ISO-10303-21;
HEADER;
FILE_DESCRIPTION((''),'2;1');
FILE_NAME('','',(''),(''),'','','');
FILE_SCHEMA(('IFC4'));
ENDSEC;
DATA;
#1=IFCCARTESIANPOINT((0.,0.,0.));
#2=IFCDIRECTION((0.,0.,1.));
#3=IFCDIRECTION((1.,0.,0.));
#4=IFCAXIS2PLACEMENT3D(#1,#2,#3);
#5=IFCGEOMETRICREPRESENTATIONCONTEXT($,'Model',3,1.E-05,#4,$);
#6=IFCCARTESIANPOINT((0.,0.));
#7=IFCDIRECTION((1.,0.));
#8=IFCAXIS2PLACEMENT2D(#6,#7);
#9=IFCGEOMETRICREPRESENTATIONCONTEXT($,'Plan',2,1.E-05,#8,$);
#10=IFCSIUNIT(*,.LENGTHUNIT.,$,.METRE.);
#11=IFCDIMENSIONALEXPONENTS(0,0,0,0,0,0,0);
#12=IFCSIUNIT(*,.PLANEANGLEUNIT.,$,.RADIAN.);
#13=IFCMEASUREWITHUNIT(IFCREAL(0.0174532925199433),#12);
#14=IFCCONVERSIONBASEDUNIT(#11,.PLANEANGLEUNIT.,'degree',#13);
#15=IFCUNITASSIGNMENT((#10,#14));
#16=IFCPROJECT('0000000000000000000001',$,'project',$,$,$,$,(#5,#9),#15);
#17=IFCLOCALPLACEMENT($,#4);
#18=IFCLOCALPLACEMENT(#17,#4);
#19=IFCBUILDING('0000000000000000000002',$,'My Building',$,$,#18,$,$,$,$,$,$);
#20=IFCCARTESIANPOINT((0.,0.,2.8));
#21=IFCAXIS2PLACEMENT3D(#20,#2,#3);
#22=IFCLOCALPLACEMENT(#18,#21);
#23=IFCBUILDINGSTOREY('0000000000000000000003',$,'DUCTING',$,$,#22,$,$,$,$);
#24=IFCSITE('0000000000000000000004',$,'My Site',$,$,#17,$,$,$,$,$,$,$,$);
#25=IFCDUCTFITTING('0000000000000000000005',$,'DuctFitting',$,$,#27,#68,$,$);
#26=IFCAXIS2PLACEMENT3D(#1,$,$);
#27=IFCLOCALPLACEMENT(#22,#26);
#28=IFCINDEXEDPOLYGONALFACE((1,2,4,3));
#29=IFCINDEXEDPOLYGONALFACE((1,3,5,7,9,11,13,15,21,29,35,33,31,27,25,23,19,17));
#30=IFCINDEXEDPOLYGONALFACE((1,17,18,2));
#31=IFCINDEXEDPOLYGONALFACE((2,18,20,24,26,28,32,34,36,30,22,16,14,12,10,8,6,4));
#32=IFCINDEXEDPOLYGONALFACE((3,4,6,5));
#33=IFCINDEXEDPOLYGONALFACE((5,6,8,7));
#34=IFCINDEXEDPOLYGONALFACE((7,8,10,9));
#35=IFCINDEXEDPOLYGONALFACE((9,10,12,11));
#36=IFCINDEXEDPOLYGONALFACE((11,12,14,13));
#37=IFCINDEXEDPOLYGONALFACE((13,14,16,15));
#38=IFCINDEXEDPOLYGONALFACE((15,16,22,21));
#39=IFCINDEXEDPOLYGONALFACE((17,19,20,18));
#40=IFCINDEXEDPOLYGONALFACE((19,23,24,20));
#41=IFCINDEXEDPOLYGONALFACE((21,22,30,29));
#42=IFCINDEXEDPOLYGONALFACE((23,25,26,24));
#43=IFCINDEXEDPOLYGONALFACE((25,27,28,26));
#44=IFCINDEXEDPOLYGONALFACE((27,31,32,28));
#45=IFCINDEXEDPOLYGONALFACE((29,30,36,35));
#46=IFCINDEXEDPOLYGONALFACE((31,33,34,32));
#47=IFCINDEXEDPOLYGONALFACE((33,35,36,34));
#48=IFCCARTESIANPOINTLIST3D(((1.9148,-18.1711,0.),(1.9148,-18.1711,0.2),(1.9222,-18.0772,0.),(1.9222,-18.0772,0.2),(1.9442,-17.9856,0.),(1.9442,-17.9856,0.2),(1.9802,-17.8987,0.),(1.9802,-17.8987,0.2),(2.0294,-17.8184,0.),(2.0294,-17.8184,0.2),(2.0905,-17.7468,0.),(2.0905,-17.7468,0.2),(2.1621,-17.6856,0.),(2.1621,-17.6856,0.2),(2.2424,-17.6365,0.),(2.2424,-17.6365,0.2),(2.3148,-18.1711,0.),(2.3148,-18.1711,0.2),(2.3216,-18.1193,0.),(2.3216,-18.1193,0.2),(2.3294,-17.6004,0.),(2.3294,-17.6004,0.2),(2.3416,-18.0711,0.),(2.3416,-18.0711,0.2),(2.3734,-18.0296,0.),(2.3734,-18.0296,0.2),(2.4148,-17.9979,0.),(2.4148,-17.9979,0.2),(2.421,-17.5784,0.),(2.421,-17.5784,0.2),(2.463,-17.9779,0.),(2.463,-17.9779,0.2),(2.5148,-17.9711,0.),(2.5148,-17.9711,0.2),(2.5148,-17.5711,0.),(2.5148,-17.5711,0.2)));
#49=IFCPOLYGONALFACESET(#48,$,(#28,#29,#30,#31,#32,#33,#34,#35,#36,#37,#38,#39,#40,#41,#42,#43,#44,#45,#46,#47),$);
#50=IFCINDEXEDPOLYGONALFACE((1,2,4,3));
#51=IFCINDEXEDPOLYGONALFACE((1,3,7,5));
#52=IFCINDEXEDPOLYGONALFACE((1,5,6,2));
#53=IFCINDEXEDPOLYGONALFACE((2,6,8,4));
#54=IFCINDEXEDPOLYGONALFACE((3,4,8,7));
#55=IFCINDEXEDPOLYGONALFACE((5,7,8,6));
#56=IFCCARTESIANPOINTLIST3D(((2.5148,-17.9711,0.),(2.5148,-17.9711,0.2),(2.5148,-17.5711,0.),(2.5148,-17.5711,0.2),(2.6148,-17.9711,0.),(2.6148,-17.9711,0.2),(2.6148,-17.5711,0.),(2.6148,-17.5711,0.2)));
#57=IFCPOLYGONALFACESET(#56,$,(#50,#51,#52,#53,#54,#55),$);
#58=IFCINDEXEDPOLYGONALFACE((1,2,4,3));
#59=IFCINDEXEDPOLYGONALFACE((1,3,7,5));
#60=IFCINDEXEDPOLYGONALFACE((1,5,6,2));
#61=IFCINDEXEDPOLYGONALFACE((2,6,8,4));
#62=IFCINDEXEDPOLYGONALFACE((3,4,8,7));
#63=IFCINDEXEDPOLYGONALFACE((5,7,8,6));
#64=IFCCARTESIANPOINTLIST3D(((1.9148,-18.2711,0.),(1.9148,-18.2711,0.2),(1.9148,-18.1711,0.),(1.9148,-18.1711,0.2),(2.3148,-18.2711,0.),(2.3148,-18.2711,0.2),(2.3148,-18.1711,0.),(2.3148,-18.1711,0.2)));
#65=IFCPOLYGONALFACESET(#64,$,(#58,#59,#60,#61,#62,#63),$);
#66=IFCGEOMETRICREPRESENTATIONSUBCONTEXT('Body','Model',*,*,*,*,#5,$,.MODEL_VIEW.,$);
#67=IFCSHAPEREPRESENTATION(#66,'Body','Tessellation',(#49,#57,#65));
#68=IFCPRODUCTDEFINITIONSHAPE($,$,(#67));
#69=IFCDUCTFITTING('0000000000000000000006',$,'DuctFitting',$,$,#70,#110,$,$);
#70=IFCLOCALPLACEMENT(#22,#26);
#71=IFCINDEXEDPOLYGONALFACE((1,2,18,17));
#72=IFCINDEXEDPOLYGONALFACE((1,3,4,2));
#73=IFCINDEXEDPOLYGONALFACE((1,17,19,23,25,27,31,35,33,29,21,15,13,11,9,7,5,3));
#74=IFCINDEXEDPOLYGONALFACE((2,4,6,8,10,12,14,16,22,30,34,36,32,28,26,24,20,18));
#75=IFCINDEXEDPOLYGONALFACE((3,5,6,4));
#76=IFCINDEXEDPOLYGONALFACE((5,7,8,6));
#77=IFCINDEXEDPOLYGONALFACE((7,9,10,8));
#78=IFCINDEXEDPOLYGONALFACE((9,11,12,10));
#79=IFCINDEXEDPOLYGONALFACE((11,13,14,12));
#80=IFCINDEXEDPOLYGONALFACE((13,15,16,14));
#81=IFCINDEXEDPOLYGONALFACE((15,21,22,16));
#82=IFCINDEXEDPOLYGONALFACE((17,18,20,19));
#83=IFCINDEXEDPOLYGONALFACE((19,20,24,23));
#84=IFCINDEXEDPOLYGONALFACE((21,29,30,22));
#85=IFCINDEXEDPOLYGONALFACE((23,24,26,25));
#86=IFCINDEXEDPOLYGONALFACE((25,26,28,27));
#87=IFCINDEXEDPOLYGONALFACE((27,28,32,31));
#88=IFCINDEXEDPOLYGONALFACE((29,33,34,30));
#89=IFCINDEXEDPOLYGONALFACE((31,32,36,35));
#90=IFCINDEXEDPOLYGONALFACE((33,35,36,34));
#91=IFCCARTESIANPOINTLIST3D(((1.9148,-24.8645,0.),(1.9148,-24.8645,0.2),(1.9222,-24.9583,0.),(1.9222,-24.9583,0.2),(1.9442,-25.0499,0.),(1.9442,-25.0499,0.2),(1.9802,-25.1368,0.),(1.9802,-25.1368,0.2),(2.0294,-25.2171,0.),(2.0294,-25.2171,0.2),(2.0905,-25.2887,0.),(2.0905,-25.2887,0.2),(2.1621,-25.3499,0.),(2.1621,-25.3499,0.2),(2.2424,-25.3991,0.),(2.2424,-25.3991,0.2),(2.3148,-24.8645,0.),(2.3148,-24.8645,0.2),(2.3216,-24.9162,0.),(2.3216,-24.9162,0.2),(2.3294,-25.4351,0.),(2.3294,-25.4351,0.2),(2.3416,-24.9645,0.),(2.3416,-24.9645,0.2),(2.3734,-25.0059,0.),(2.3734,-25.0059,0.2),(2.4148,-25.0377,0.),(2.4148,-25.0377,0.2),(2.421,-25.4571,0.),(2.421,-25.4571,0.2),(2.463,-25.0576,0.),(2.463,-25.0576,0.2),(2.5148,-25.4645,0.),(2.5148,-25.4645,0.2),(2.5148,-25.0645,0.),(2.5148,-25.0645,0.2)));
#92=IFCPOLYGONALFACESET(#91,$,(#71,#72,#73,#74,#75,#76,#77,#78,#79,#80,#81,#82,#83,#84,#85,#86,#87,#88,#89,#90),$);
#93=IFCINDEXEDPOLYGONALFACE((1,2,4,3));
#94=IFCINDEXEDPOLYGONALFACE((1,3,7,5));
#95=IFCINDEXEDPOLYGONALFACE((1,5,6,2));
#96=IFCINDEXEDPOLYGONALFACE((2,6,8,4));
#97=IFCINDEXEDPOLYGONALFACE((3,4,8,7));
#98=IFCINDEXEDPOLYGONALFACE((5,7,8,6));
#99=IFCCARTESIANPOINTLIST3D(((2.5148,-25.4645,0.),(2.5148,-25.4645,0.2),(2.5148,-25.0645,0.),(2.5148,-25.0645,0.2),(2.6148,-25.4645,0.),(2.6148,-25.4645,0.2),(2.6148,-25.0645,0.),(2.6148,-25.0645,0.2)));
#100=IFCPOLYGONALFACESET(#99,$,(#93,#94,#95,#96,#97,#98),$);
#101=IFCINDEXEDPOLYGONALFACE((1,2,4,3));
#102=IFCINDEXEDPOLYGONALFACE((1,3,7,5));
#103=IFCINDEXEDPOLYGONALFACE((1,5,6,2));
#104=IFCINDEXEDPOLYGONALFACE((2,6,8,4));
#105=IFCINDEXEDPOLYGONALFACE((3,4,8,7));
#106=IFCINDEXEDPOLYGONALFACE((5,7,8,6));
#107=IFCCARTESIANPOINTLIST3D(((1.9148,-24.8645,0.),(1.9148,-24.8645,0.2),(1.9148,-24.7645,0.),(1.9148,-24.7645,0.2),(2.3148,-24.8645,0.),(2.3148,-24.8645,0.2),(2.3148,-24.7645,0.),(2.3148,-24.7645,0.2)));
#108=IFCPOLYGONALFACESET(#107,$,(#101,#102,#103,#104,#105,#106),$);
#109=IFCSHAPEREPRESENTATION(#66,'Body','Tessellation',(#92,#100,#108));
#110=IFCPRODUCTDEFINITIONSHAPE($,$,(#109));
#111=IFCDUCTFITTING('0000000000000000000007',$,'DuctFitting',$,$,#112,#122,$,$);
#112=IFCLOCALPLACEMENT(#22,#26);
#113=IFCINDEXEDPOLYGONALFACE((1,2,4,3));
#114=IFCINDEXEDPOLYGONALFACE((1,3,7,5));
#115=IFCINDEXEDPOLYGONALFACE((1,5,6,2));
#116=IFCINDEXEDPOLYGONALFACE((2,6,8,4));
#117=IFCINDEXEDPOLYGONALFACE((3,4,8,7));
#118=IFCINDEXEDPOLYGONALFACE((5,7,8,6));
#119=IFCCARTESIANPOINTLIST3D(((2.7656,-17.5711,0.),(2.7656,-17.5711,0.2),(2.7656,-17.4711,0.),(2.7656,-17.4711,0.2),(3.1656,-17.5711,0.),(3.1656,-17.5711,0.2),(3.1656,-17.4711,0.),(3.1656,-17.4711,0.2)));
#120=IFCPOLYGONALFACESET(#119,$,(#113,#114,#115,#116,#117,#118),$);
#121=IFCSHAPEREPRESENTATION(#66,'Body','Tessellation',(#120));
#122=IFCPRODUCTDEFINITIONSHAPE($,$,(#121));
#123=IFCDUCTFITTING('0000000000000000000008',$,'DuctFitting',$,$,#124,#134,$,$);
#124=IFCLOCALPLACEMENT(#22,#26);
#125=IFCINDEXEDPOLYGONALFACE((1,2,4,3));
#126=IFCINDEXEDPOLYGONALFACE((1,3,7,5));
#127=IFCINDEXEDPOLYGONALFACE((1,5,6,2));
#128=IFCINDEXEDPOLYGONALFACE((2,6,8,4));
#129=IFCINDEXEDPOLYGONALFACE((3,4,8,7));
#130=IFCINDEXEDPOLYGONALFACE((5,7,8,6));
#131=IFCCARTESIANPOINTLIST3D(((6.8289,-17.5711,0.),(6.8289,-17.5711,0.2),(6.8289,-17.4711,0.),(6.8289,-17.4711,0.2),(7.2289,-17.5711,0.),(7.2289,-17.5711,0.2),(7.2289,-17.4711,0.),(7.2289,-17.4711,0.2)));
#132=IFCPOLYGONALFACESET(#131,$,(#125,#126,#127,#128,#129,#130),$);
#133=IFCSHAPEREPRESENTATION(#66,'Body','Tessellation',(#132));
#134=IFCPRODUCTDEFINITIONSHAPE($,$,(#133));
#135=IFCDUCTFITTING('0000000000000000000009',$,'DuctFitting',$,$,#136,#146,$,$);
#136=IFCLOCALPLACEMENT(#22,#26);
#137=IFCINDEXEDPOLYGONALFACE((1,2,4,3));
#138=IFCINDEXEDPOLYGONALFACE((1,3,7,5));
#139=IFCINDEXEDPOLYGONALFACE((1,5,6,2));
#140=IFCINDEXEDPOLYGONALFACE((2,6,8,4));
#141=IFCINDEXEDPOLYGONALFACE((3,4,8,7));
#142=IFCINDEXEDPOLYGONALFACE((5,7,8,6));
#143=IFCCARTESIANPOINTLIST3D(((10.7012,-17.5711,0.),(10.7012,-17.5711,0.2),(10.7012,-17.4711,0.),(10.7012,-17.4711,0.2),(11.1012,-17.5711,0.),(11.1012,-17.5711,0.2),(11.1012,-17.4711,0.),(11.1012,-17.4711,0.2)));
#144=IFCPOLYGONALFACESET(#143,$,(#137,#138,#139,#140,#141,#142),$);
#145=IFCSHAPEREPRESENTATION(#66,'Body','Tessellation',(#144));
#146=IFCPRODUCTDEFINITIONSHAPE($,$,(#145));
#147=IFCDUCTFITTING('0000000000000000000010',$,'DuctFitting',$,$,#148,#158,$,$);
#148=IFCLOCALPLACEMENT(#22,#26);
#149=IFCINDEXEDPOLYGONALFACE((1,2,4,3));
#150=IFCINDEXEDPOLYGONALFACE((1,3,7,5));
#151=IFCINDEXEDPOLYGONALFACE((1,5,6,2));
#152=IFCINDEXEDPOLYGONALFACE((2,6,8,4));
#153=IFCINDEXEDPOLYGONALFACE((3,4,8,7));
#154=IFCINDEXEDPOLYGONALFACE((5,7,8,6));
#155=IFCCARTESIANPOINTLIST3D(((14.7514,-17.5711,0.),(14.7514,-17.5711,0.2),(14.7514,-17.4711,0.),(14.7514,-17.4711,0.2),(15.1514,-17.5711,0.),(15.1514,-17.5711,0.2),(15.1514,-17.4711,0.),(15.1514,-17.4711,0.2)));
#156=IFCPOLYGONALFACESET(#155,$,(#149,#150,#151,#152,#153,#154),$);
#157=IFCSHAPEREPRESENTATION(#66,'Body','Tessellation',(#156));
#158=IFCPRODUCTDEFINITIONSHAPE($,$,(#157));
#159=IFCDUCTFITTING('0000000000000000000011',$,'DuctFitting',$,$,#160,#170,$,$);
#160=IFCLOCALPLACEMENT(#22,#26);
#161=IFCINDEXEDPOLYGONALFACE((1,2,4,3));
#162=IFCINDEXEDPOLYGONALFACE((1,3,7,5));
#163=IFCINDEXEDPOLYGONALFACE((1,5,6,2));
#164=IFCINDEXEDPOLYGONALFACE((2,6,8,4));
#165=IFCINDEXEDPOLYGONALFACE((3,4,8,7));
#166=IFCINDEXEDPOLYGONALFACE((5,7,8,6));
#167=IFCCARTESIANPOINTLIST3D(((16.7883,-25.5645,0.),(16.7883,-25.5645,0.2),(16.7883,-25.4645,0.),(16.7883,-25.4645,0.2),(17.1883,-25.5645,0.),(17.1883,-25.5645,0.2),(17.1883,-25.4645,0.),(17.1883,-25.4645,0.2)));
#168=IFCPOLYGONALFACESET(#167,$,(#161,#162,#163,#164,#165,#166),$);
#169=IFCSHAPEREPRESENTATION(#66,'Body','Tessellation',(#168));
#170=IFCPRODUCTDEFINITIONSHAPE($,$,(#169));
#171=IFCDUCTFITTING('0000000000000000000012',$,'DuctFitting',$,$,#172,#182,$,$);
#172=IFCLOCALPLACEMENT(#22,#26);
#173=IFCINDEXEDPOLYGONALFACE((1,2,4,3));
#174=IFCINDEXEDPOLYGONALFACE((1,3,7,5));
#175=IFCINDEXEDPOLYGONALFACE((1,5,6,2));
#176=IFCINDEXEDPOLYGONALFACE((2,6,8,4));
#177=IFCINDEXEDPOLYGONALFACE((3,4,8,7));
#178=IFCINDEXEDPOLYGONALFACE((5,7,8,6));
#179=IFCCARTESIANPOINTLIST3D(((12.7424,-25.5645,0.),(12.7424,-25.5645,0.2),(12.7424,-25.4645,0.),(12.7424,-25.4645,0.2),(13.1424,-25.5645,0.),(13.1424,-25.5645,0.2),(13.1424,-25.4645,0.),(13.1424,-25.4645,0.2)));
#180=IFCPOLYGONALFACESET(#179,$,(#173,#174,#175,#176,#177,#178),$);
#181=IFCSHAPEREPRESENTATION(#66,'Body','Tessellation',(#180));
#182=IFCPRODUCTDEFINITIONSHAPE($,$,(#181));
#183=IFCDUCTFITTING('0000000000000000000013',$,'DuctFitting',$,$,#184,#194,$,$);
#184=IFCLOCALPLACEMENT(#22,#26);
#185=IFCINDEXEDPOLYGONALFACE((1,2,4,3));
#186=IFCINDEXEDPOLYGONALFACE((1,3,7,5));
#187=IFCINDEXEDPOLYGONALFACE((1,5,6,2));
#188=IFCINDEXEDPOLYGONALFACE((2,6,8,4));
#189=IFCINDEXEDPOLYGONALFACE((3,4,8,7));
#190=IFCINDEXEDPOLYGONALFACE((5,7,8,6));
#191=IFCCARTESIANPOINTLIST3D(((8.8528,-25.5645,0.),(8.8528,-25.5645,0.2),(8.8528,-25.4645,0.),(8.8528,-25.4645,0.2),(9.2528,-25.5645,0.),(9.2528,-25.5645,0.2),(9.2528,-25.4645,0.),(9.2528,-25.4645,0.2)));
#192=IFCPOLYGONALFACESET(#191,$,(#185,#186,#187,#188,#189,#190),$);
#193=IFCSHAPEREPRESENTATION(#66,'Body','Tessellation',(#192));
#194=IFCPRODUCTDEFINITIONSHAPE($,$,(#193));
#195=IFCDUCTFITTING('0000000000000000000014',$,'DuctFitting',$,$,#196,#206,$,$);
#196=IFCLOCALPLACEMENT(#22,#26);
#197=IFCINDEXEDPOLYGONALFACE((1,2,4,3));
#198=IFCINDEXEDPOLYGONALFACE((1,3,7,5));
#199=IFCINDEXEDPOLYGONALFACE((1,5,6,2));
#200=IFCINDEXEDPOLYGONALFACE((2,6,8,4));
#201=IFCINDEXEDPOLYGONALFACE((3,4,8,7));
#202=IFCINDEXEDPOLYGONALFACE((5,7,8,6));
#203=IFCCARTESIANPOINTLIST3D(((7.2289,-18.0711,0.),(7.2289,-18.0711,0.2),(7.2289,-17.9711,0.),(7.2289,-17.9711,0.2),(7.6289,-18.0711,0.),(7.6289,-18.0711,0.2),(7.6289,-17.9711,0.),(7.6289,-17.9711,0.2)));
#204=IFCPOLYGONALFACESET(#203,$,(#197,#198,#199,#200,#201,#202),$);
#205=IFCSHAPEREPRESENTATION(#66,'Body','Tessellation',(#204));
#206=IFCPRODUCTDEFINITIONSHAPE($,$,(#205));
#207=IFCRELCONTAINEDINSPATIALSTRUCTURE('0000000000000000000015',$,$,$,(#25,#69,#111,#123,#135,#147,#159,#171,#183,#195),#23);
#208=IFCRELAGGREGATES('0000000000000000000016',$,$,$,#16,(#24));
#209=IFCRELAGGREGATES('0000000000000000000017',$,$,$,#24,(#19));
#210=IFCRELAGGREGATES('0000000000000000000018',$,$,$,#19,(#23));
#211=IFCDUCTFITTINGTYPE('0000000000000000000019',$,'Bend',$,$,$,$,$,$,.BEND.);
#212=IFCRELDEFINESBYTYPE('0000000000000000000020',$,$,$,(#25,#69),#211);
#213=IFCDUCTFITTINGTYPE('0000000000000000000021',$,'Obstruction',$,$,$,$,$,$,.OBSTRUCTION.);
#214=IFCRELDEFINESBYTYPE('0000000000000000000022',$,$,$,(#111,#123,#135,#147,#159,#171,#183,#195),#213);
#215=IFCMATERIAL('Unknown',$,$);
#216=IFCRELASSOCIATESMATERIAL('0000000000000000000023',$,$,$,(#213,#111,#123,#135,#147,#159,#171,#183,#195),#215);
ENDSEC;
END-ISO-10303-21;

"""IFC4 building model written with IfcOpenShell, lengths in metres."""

from ifc_helpers import new_model, entity, si_unit, converted_unit, frame, origin_with_axes, origin_2d_with_axis, place, context, subcontext, project, spatial, line, arc, indexed_curve, rectangle, outline, extrude, source, transform, mapped, material, material_profile, profile_set, profile_usage, type_object, type_shapes, element, save


model = new_model("IFC4")

# Units and contexts
model_context = context("Model", 3, precision=1e-05, world=origin_with_axes())
plan_context = context("Plan", 2, precision=1e-05, world=origin_2d_with_axis())
body_context = subcontext(model_context, "Body", "Model", "MODEL_VIEW")
ifc_project = project(units=[si_unit("LENGTHUNIT", "METRE"), converted_unit("PLANEANGLEUNIT", "degree", entity("IfcReal", 0.0174532925199433), si_unit("PLANEANGLEUNIT", "RADIAN"), dimensions=[0, 0, 0, 0, 0, 0, 0])], contexts=[model_context, plan_context])

# Site, building, storey
site_placement = place(None, origin_with_axes())
site = spatial("IfcSite", under=ifc_project, at=site_placement, Name="My Site")
building_placement = place(site_placement, origin_with_axes())
building = spatial("IfcBuilding", under=site, at=building_placement, Name="My Building")
storey_placement = place(building_placement, frame((0.0, 0.0, 2.8), z_axis=(0.0, 0.0, 1.0), x_axis=(1.0, 0.0, 0.0)))
storey = spatial("IfcBuildingStorey", under=building, at=storey_placement, Name="DUCTING")

# Shared definitions
ifc_material = material(Name="Unknown")

# Duct fittings
duct_fitting_type_1 = type_object("IfcDuctFittingType", Name="Bend", PredefinedType="BEND")
shared_shape = source(origin_with_axes(), body_context, "Body", "SweptSolid", [
    extrude(outline(indexed_curve([(0.2, 0.0), (0.2586, -0.1414), (0.4, -0.2), (0.4, -0.6), (-0.0243, -0.4243), (-0.2, 0.0)], segments=[arc(1, 2, 3), line(3, 4), arc(4, 5, 6), line(6, 1)])), frame((0.0, -0.1, -0.1), z_axis=(0.0, -1.0, 0.0), x_axis=(1.0, 0.0, 0.0)), (0.0, 0.0, -1.0), 0.2),
    extrude(rectangle(XDim=0.4, YDim=0.2), origin_with_axes(), (0.0, 0.0, -1.0), 0.1),
    extrude(rectangle(XDim=0.4, YDim=0.2), frame((0.4, 0.0, -0.5), z_axis=(1.0, 0.0, 0.0), x_axis=(0.0, 0.0, 1.0)), (0.0, 0.0, 1.0), 0.1),
])
type_shapes(duct_fitting_type_1, [shared_shape])
for number, where, z_axis, x_axis, name in (
    (1, (2.6148, -17.7711, 0.1), (1.0, 0.0, 0.0), (0.0, -1.0, 0.0), "DuctFitting"),
    (2, (2.6148, -25.2645, 0.1), (1.0, 0.0, 0.0), (0.0, 1.0, 0.0), "DuctFitting"),
):
    element("IfcDuctFitting", number, at=place(storey_placement, frame(where, z_axis=z_axis, x_axis=x_axis)), inside=storey, type_object=duct_fitting_type_1, Name=name, context=body_context, shape_type="MappedRepresentation", body=[
        mapped(shared_shape, transform((0.0, 0.0, 0.0), x_axis=(1.0, 0.0, 0.0), y_axis=(0.0, 1.0, 0.0), z_axis=(0.0, 0.0, 1.0), scale=1.0)),
    ])
ifc_material_profile_1 = material_profile(ifc_material, rectangle(XDim=0.4, YDim=0.2))
ifc_profile_set_1 = profile_set([ifc_material_profile_1])
ifc_profile_usage_1 = profile_usage(ifc_profile_set_1, cardinal=5)
duct_fitting_type_2 = type_object("IfcDuctFittingType", Name="Obstruction", PredefinedType="OBSTRUCTION", material=ifc_profile_set_1)
duct_fitting_1_placement = place(storey_placement, frame((2.9656, -17.5711, 0.1), z_axis=(0.0, 1.0, 0.0), x_axis=(-1.0, 0.0, 0.0)))
element("IfcDuctFitting", 3, at=duct_fitting_1_placement, inside=storey, type_object=duct_fitting_type_2, material=ifc_profile_usage_1, Name="DuctFitting", context=body_context, shape_type="SweptSolid", body=[
    extrude(rectangle(XDim=0.4, YDim=0.2), origin_with_axes(), (0.0, 0.0, 1.0), 0.1),
])
ifc_profile_usage_2 = profile_usage(ifc_profile_set_1, cardinal=5)
duct_fitting_2_placement = place(storey_placement, frame((7.0289, -17.5711, 0.1), z_axis=(0.0, 1.0, 0.0), x_axis=(-1.0, 0.0, 0.0)))
element("IfcDuctFitting", 4, at=duct_fitting_2_placement, inside=storey, type_object=duct_fitting_type_2, material=ifc_profile_usage_2, Name="DuctFitting", context=body_context, shape_type="SweptSolid", body=[
    extrude(rectangle(XDim=0.4, YDim=0.2), origin_with_axes(), (0.0, 0.0, 1.0), 0.1),
])
ifc_profile_usage_3 = profile_usage(ifc_profile_set_1, cardinal=5)
duct_fitting_3_placement = place(storey_placement, frame((10.9012, -17.5711, 0.1), z_axis=(0.0, 1.0, 0.0), x_axis=(-1.0, 0.0, 0.0)))
element("IfcDuctFitting", 5, at=duct_fitting_3_placement, inside=storey, type_object=duct_fitting_type_2, material=ifc_profile_usage_3, Name="DuctFitting", context=body_context, shape_type="SweptSolid", body=[
    extrude(rectangle(XDim=0.4, YDim=0.2), origin_with_axes(), (0.0, 0.0, 1.0), 0.1),
])
ifc_profile_usage_4 = profile_usage(ifc_profile_set_1, cardinal=5)
duct_fitting_4_placement = place(storey_placement, frame((14.9514, -17.5711, 0.1), z_axis=(0.0, 1.0, 0.0), x_axis=(-1.0, 0.0, 0.0)))
element("IfcDuctFitting", 6, at=duct_fitting_4_placement, inside=storey, type_object=duct_fitting_type_2, material=ifc_profile_usage_4, Name="DuctFitting", context=body_context, shape_type="SweptSolid", body=[
    extrude(rectangle(XDim=0.4, YDim=0.2), origin_with_axes(), (0.0, 0.0, 1.0), 0.1),
])
ifc_profile_usage_5 = profile_usage(ifc_profile_set_1, cardinal=5)
duct_fitting_5_placement = place(storey_placement, frame((16.9883, -25.5645, 0.1), z_axis=(0.0, 1.0, 0.0), x_axis=(-1.0, 0.0, 0.0)))
element("IfcDuctFitting", 7, at=duct_fitting_5_placement, inside=storey, type_object=duct_fitting_type_2, material=ifc_profile_usage_5, Name="DuctFitting", context=body_context, shape_type="SweptSolid", body=[
    extrude(rectangle(XDim=0.4, YDim=0.2), origin_with_axes(), (0.0, 0.0, 1.0), 0.1),
])
ifc_profile_usage_6 = profile_usage(ifc_profile_set_1, cardinal=5)
duct_fitting_6_placement = place(storey_placement, frame((12.9424, -25.5645, 0.1), z_axis=(0.0, 1.0, 0.0), x_axis=(-1.0, 0.0, 0.0)))
element("IfcDuctFitting", 8, at=duct_fitting_6_placement, inside=storey, type_object=duct_fitting_type_2, material=ifc_profile_usage_6, Name="DuctFitting", context=body_context, shape_type="SweptSolid", body=[
    extrude(rectangle(XDim=0.4, YDim=0.2), origin_with_axes(), (0.0, 0.0, 1.0), 0.1),
])
ifc_profile_usage_7 = profile_usage(ifc_profile_set_1, cardinal=5)
duct_fitting_7_placement = place(storey_placement, frame((9.0528, -25.5645, 0.1), z_axis=(0.0, 1.0, 0.0), x_axis=(-1.0, 0.0, 0.0)))
element("IfcDuctFitting", 9, at=duct_fitting_7_placement, inside=storey, type_object=duct_fitting_type_2, material=ifc_profile_usage_7, Name="DuctFitting", context=body_context, shape_type="SweptSolid", body=[
    extrude(rectangle(XDim=0.4, YDim=0.2), origin_with_axes(), (0.0, 0.0, 1.0), 0.1),
])
ifc_profile_usage_8 = profile_usage(ifc_profile_set_1, cardinal=5)
duct_fitting_8_placement = place(storey_placement, frame((7.4289, -17.9711, 0.1), z_axis=(0.0, -1.0, 0.0), x_axis=(1.0, 0.0, 0.0)))
element("IfcDuctFitting", 10, at=duct_fitting_8_placement, inside=storey, type_object=duct_fitting_type_2, material=ifc_profile_usage_8, Name="DuctFitting", context=body_context, shape_type="SweptSolid", body=[
    extrude(rectangle(XDim=0.4, YDim=0.2), origin_with_axes(), (0.0, 0.0, 1.0), 0.1),
])

save(model, "model.ifc")
